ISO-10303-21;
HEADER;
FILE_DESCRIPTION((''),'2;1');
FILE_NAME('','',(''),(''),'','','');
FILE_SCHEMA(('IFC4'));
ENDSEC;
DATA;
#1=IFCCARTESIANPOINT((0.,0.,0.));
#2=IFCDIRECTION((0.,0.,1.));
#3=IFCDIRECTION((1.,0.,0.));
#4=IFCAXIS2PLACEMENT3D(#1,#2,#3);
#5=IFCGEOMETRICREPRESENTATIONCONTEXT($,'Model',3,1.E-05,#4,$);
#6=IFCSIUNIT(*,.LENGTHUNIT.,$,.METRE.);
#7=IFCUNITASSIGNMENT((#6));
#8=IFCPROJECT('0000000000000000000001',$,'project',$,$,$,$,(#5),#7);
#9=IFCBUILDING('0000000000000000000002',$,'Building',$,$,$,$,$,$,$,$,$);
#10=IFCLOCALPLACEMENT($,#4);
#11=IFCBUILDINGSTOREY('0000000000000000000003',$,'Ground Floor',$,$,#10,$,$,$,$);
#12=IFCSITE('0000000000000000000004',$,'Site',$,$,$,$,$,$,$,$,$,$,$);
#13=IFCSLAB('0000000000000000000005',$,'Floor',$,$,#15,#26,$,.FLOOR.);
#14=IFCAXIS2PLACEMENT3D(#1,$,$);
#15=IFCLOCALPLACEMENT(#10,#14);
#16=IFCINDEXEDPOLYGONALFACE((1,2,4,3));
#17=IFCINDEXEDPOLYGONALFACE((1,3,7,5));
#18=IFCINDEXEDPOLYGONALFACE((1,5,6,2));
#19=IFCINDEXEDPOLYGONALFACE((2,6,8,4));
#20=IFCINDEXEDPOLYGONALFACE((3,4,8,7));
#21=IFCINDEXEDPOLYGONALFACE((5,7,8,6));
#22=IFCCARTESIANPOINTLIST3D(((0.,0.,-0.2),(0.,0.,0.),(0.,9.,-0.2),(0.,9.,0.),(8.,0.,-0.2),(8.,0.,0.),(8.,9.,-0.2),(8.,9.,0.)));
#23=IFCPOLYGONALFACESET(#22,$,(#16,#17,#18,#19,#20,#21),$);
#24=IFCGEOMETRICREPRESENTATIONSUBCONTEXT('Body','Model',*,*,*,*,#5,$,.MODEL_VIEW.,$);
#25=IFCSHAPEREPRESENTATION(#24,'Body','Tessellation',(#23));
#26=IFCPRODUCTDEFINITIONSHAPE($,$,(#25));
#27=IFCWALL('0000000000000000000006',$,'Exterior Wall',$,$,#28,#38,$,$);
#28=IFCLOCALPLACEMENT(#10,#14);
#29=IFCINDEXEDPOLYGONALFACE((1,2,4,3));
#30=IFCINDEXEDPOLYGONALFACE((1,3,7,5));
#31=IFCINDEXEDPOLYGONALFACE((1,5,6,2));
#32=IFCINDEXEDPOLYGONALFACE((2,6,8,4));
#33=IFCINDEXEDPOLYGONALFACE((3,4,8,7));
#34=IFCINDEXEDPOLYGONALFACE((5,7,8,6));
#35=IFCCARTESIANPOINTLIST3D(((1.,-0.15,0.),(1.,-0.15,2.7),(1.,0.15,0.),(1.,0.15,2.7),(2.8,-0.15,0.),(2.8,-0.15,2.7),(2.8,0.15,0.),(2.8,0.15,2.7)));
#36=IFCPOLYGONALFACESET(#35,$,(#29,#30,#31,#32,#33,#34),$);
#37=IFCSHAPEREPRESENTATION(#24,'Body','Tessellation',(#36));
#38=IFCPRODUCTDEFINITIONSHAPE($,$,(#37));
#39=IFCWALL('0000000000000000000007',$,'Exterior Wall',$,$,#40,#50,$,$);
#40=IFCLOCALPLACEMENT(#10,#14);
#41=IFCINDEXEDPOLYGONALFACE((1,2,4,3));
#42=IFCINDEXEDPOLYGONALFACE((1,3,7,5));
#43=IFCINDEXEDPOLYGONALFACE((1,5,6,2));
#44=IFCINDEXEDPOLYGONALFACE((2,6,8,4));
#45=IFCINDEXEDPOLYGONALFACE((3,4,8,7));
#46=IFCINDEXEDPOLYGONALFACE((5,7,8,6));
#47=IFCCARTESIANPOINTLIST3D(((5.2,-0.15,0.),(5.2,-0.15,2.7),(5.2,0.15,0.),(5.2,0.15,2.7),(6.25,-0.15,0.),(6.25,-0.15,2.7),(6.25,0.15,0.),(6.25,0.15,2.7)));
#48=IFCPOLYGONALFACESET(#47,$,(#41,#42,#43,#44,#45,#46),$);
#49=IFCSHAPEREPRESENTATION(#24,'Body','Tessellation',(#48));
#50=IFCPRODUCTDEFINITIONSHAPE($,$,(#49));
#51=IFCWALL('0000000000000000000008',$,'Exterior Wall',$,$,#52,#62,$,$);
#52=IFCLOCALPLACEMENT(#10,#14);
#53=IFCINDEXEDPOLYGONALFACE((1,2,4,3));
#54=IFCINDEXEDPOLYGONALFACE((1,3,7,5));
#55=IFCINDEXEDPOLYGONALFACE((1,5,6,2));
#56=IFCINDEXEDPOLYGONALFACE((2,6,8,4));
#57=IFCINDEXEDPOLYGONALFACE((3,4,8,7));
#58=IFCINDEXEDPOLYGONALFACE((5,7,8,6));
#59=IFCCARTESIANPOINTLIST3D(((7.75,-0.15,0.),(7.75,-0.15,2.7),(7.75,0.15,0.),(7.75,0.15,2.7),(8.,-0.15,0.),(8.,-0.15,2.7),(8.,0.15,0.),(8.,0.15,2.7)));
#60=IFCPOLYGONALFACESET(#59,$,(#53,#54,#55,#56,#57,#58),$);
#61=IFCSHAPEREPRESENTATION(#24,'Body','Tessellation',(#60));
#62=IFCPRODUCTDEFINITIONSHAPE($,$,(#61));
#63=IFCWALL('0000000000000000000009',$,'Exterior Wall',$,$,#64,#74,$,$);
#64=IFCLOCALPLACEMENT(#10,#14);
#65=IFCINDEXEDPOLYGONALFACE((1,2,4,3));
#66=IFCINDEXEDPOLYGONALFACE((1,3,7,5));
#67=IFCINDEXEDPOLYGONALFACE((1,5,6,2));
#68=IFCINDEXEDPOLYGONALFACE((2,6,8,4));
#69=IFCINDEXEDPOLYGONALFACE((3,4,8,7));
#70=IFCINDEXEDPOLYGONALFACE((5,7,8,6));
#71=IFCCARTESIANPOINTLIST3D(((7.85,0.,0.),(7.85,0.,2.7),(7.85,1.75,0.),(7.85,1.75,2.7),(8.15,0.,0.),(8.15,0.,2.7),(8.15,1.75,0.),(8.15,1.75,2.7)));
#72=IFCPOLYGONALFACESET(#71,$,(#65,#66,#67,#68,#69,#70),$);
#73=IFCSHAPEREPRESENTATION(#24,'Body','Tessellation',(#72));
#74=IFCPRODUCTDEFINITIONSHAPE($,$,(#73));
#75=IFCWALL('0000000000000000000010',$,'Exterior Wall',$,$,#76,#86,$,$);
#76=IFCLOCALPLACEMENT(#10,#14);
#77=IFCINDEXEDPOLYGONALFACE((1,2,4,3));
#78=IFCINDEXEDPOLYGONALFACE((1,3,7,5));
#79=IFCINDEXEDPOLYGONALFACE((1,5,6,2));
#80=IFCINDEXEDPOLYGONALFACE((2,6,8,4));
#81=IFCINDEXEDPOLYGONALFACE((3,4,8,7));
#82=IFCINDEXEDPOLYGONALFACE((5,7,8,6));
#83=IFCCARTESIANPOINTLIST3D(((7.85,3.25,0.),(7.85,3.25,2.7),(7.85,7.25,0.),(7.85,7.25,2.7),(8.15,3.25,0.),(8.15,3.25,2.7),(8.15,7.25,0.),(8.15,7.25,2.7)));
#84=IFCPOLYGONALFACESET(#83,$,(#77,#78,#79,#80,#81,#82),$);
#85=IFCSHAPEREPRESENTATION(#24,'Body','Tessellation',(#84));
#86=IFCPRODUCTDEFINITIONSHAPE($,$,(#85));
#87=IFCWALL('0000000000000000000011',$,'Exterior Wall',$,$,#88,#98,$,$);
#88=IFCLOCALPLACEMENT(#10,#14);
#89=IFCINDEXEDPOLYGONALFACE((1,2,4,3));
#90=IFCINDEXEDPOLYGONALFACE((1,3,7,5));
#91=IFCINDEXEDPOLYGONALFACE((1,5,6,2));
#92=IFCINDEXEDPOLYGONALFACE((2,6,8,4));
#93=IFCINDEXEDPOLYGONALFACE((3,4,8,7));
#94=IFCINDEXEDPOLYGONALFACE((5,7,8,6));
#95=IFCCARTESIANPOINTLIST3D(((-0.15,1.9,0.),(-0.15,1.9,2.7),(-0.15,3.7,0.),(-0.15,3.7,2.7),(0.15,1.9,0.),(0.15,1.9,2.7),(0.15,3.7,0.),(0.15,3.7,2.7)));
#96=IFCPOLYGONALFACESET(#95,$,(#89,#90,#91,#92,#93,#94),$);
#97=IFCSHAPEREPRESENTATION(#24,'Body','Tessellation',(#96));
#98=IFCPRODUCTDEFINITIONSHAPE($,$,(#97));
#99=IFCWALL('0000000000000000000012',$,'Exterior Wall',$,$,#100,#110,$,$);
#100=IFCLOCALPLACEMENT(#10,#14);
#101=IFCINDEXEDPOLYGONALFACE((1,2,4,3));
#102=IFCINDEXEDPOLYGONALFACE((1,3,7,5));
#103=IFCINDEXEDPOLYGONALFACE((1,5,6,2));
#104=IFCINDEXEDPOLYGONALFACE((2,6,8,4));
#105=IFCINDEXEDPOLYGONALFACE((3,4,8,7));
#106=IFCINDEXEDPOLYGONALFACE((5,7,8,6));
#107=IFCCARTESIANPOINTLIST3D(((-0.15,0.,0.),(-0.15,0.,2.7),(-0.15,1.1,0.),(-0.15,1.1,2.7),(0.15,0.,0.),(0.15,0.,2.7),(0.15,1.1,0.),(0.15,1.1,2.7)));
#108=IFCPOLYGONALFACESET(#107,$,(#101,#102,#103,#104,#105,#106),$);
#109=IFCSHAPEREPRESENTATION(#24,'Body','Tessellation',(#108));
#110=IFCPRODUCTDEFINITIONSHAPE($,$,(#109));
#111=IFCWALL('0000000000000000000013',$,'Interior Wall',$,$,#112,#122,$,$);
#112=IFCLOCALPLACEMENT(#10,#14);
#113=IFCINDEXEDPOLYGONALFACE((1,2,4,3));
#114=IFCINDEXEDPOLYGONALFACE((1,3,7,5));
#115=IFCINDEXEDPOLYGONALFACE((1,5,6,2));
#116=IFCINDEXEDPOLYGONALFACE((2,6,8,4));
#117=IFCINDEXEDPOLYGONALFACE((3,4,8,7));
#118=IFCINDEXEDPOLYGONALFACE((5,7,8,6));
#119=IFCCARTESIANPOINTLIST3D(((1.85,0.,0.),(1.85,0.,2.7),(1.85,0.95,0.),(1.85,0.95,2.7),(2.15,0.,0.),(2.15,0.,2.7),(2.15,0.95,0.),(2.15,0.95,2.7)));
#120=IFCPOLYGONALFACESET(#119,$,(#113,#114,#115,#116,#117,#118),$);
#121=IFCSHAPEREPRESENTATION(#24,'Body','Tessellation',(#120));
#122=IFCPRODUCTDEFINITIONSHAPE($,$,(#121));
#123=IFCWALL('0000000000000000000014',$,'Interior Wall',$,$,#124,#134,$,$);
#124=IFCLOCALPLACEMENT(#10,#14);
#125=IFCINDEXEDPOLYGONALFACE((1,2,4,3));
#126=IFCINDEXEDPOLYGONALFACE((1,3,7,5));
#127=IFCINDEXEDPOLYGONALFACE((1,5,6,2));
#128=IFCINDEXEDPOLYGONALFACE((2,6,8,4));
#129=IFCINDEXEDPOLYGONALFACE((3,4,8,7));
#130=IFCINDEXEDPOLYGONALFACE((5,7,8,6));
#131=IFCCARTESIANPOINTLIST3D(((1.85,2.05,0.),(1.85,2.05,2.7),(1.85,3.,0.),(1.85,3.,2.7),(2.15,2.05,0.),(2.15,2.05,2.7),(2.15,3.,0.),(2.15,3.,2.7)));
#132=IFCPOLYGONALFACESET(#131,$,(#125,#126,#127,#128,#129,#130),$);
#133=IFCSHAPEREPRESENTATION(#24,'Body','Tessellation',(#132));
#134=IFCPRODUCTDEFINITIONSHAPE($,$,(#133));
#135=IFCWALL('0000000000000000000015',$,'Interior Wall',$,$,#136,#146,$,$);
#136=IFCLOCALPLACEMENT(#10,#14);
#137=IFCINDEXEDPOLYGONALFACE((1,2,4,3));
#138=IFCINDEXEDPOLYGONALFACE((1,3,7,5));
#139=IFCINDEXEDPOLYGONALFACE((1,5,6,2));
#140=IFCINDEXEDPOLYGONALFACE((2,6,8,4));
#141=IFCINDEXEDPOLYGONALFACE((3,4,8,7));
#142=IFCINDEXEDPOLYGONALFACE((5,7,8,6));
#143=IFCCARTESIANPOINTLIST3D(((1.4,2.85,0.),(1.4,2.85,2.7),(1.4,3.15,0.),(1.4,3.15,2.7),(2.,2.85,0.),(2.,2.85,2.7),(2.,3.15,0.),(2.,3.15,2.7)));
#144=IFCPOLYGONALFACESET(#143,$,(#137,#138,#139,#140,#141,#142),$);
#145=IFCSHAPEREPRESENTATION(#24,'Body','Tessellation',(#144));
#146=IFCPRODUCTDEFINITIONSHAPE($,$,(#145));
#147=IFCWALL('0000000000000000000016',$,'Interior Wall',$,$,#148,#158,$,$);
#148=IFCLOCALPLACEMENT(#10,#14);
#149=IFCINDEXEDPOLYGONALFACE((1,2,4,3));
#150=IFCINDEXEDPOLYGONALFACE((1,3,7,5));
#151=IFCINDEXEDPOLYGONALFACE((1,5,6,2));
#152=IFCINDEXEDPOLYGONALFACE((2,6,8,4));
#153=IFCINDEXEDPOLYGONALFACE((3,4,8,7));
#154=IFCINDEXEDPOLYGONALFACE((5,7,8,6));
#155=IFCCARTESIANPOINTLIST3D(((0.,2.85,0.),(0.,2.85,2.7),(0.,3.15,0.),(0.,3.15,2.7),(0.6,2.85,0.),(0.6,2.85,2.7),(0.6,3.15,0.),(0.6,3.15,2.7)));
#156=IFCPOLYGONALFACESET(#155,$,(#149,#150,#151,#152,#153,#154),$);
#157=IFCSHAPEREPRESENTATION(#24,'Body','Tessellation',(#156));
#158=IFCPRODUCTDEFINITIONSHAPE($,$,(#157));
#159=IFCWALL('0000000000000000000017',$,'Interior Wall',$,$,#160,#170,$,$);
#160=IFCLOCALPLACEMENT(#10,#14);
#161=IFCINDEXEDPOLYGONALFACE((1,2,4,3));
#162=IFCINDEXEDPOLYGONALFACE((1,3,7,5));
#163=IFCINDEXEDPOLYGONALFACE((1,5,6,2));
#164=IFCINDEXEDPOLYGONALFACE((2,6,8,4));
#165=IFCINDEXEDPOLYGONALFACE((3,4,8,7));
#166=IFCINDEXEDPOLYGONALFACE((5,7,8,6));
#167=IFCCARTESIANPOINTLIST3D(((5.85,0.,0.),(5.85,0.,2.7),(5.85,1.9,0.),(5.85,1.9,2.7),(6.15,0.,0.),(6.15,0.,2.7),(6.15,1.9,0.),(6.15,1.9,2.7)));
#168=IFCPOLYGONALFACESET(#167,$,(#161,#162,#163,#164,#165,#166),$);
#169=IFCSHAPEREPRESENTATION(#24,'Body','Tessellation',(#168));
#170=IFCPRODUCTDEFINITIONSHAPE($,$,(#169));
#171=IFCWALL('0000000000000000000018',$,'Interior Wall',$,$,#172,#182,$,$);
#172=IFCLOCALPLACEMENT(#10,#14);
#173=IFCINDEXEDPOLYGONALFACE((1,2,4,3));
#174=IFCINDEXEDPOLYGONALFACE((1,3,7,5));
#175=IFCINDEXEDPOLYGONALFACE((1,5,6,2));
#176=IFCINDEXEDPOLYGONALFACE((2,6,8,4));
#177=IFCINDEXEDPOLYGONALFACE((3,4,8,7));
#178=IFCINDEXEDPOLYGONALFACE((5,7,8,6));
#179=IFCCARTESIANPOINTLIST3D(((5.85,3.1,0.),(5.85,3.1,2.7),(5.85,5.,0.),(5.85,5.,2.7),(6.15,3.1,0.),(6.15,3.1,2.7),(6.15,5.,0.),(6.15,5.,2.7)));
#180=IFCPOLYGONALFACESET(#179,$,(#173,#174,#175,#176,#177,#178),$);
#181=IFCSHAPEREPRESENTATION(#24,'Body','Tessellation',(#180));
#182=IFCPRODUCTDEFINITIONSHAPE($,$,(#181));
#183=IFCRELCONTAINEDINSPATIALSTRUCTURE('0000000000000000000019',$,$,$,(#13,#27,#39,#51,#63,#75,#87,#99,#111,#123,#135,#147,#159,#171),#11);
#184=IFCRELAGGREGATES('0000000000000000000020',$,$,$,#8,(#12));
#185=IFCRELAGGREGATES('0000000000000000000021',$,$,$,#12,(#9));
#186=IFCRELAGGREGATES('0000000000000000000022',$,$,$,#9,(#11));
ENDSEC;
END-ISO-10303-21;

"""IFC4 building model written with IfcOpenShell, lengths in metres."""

from ifc_helpers import new_model, si_unit, frame, origin_with_axes, place, context, subcontext, project, spatial, indexed_curve, outline, extrude, element, save


model = new_model("IFC4")

# Units and contexts
model_context = context("Model", 3, precision=1e-05, world=origin_with_axes())
body_context = subcontext(model_context, "Body", "Model", "MODEL_VIEW")
ifc_project = project(units=[si_unit("LENGTHUNIT", "METRE")], contexts=[model_context])

# Site, building, storey
site = spatial("IfcSite", under=ifc_project, Name="Site")
building = spatial("IfcBuilding", under=site, Name="Building")
storey_placement = place(None, origin_with_axes())
storey = spatial("IfcBuildingStorey", under=building, at=storey_placement, Name="Ground Floor")

# Slab
slab_placement = place(storey_placement, frame((0.0, 0.0, -0.2), z_axis=(0.0, 0.0, 1.0), x_axis=(1.0, 0.0, 0.0)))
element("IfcSlab", 1, at=slab_placement, inside=storey, Name="Floor", PredefinedType="FLOOR", context=body_context, shape_type="SweptSolid", body=[
    extrude(outline(indexed_curve([(0.0, 0.0), (8.0, 0.0), (8.0, 9.0), (0.0, 9.0)])), None, (0.0, 0.0, 1.0), 0.2),
])

# Walls
wall_1_placement = place(storey_placement, frame((1.0, 0.0, 0.0), z_axis=(0.0, 0.0, 1.0), x_axis=(1.0, 0.0, 0.0)))
element("IfcWall", 2, at=wall_1_placement, inside=storey, Name="Exterior Wall", context=body_context, shape_type="SweptSolid", body=[
    extrude(outline(indexed_curve([(0.0, 0.0), (0.0, 0.3), (1.8, 0.3), (1.8, 0.0), (0.0, 0.0)], self_intersect=False)), frame((0.0, -0.15, 0.0), z_axis=(0.0, 0.0, 1.0), x_axis=(1.0, 0.0, 0.0)), (0.0, 0.0, 1.0), 2.7),
])
wall_2_placement = place(storey_placement, frame((5.2, 0.0, 0.0), z_axis=(0.0, 0.0, 1.0), x_axis=(1.0, 0.0, 0.0)))
element("IfcWall", 3, at=wall_2_placement, inside=storey, Name="Exterior Wall", context=body_context, shape_type="SweptSolid", body=[
    extrude(outline(indexed_curve([(0.0, 0.0), (0.0, 0.3), (1.05, 0.3), (1.05, 0.0), (0.0, 0.0)], self_intersect=False)), frame((0.0, -0.15, 0.0), z_axis=(0.0, 0.0, 1.0), x_axis=(1.0, 0.0, 0.0)), (0.0, 0.0, 1.0), 2.7),
])
wall_3_placement = place(storey_placement, frame((7.75, 0.0, 0.0), z_axis=(0.0, 0.0, 1.0), x_axis=(1.0, 0.0, 0.0)))
element("IfcWall", 4, at=wall_3_placement, inside=storey, Name="Exterior Wall", context=body_context, shape_type="SweptSolid", body=[
    extrude(outline(indexed_curve([(0.0, 0.0), (0.0, 0.3), (0.25, 0.3), (0.25, 0.0), (0.0, 0.0)], self_intersect=False)), frame((0.0, -0.15, 0.0), z_axis=(0.0, 0.0, 1.0), x_axis=(1.0, 0.0, 0.0)), (0.0, 0.0, 1.0), 2.7),
])
wall_4_placement = place(storey_placement, frame((8.0, 0.0, 0.0), z_axis=(0.0, 0.0, 1.0), x_axis=(0.0, 1.0, 0.0)))
element("IfcWall", 5, at=wall_4_placement, inside=storey, Name="Exterior Wall", context=body_context, shape_type="SweptSolid", body=[
    extrude(outline(indexed_curve([(0.0, 0.0), (0.0, 0.3), (1.75, 0.3), (1.75, 0.0), (0.0, 0.0)], self_intersect=False)), frame((0.0, -0.15, 0.0), z_axis=(0.0, 0.0, 1.0), x_axis=(1.0, 0.0, 0.0)), (0.0, 0.0, 1.0), 2.7),
])
wall_5_placement = place(storey_placement, frame((8.0, 3.25, 0.0), z_axis=(0.0, 0.0, 1.0), x_axis=(0.0, 1.0, 0.0)))
element("IfcWall", 6, at=wall_5_placement, inside=storey, Name="Exterior Wall", context=body_context, shape_type="SweptSolid", body=[
    extrude(outline(indexed_curve([(0.0, 0.0), (0.0, 0.3), (4.0, 0.3), (4.0, 0.0), (0.0, 0.0)], self_intersect=False)), frame((0.0, -0.15, 0.0), z_axis=(0.0, 0.0, 1.0), x_axis=(1.0, 0.0, 0.0)), (0.0, 0.0, 1.0), 2.7),
])
wall_6_placement = place(storey_placement, frame((0.0, 3.7, 0.0), z_axis=(0.0, 0.0, 1.0), x_axis=(0.0, -1.0, 0.0)))
element("IfcWall", 7, at=wall_6_placement, inside=storey, Name="Exterior Wall", context=body_context, shape_type="SweptSolid", body=[
    extrude(outline(indexed_curve([(0.0, 0.0), (0.0, 0.3), (1.8, 0.3), (1.8, 0.0), (0.0, 0.0)], self_intersect=False)), frame((0.0, -0.15, 0.0), z_axis=(0.0, 0.0, 1.0), x_axis=(1.0, 0.0, 0.0)), (0.0, 0.0, 1.0), 2.7),
])
wall_7_placement = place(storey_placement, frame((0.0, 1.1, 0.0), z_axis=(0.0, 0.0, 1.0), x_axis=(0.0, -1.0, 0.0)))
element("IfcWall", 8, at=wall_7_placement, inside=storey, Name="Exterior Wall", context=body_context, shape_type="SweptSolid", body=[
    extrude(outline(indexed_curve([(0.0, 0.0), (0.0, 0.3), (1.1, 0.3), (1.1, 0.0), (0.0, 0.0)], self_intersect=False)), frame((0.0, -0.15, 0.0), z_axis=(0.0, 0.0, 1.0), x_axis=(1.0, 0.0, 0.0)), (0.0, 0.0, 1.0), 2.7),
])
wall_8_placement = place(storey_placement, frame((2.0, 0.0, 0.0), z_axis=(0.0, 0.0, 1.0), x_axis=(0.0, 1.0, 0.0)))
element("IfcWall", 9, at=wall_8_placement, inside=storey, Name="Interior Wall", context=body_context, shape_type="SweptSolid", body=[
    extrude(outline(indexed_curve([(0.0, 0.0), (0.0, 0.3), (0.95, 0.3), (0.95, 0.0), (0.0, 0.0)], self_intersect=False)), frame((0.0, -0.15, 0.0), z_axis=(0.0, 0.0, 1.0), x_axis=(1.0, 0.0, 0.0)), (0.0, 0.0, 1.0), 2.7),
])
wall_9_placement = place(storey_placement, frame((2.0, 2.05, 0.0), z_axis=(0.0, 0.0, 1.0), x_axis=(0.0, 1.0, 0.0)))
element("IfcWall", 10, at=wall_9_placement, inside=storey, Name="Interior Wall", context=body_context, shape_type="SweptSolid", body=[
    extrude(outline(indexed_curve([(0.0, 0.0), (0.0, 0.3), (0.95, 0.3), (0.95, 0.0), (0.0, 0.0)], self_intersect=False)), frame((0.0, -0.15, 0.0), z_axis=(0.0, 0.0, 1.0), x_axis=(1.0, 0.0, 0.0)), (0.0, 0.0, 1.0), 2.7),
])
for number, where, z_axis, x_axis, name in (
    (11, (2.0, 3.0, 0.0), (0.0, 0.0, 1.0), (-1.0, 0.0, 0.0), "Interior Wall"),
    (12, (0.6, 3.0, 0.0), (0.0, 0.0, 1.0), (-1.0, 0.0, 0.0), "Interior Wall"),
):
    element("IfcWall", number, at=place(storey_placement, frame(where, z_axis=z_axis, x_axis=x_axis)), inside=storey, Name=name, context=body_context, shape_type="SweptSolid", body=[
        extrude(outline(indexed_curve([(0.0, 0.0), (0.0, 0.3), (0.6, 0.3), (0.6, 0.0), (0.0, 0.0)], self_intersect=False)), frame((0.0, -0.15, 0.0), z_axis=(0.0, 0.0, 1.0), x_axis=(1.0, 0.0, 0.0)), (0.0, 0.0, 1.0), 2.7),
    ])
for number, where, z_axis, x_axis, name in (
    (13, (6.0, 0.0, 0.0), (0.0, 0.0, 1.0), (0.0, 1.0, 0.0), "Interior Wall"),
    (14, (6.0, 3.1, 0.0), (0.0, 0.0, 1.0), (0.0, 1.0, 0.0), "Interior Wall"),
):
    element("IfcWall", number, at=place(storey_placement, frame(where, z_axis=z_axis, x_axis=x_axis)), inside=storey, Name=name, context=body_context, shape_type="SweptSolid", body=[
        extrude(outline(indexed_curve([(0.0, 0.0), (0.0, 0.3), (1.9, 0.3), (1.9, 0.0), (0.0, 0.0)], self_intersect=False)), frame((0.0, -0.15, 0.0), z_axis=(0.0, 0.0, 1.0), x_axis=(1.0, 0.0, 0.0)), (0.0, 0.0, 1.0), 2.7),
    ])

save(model, "model.ifc")
